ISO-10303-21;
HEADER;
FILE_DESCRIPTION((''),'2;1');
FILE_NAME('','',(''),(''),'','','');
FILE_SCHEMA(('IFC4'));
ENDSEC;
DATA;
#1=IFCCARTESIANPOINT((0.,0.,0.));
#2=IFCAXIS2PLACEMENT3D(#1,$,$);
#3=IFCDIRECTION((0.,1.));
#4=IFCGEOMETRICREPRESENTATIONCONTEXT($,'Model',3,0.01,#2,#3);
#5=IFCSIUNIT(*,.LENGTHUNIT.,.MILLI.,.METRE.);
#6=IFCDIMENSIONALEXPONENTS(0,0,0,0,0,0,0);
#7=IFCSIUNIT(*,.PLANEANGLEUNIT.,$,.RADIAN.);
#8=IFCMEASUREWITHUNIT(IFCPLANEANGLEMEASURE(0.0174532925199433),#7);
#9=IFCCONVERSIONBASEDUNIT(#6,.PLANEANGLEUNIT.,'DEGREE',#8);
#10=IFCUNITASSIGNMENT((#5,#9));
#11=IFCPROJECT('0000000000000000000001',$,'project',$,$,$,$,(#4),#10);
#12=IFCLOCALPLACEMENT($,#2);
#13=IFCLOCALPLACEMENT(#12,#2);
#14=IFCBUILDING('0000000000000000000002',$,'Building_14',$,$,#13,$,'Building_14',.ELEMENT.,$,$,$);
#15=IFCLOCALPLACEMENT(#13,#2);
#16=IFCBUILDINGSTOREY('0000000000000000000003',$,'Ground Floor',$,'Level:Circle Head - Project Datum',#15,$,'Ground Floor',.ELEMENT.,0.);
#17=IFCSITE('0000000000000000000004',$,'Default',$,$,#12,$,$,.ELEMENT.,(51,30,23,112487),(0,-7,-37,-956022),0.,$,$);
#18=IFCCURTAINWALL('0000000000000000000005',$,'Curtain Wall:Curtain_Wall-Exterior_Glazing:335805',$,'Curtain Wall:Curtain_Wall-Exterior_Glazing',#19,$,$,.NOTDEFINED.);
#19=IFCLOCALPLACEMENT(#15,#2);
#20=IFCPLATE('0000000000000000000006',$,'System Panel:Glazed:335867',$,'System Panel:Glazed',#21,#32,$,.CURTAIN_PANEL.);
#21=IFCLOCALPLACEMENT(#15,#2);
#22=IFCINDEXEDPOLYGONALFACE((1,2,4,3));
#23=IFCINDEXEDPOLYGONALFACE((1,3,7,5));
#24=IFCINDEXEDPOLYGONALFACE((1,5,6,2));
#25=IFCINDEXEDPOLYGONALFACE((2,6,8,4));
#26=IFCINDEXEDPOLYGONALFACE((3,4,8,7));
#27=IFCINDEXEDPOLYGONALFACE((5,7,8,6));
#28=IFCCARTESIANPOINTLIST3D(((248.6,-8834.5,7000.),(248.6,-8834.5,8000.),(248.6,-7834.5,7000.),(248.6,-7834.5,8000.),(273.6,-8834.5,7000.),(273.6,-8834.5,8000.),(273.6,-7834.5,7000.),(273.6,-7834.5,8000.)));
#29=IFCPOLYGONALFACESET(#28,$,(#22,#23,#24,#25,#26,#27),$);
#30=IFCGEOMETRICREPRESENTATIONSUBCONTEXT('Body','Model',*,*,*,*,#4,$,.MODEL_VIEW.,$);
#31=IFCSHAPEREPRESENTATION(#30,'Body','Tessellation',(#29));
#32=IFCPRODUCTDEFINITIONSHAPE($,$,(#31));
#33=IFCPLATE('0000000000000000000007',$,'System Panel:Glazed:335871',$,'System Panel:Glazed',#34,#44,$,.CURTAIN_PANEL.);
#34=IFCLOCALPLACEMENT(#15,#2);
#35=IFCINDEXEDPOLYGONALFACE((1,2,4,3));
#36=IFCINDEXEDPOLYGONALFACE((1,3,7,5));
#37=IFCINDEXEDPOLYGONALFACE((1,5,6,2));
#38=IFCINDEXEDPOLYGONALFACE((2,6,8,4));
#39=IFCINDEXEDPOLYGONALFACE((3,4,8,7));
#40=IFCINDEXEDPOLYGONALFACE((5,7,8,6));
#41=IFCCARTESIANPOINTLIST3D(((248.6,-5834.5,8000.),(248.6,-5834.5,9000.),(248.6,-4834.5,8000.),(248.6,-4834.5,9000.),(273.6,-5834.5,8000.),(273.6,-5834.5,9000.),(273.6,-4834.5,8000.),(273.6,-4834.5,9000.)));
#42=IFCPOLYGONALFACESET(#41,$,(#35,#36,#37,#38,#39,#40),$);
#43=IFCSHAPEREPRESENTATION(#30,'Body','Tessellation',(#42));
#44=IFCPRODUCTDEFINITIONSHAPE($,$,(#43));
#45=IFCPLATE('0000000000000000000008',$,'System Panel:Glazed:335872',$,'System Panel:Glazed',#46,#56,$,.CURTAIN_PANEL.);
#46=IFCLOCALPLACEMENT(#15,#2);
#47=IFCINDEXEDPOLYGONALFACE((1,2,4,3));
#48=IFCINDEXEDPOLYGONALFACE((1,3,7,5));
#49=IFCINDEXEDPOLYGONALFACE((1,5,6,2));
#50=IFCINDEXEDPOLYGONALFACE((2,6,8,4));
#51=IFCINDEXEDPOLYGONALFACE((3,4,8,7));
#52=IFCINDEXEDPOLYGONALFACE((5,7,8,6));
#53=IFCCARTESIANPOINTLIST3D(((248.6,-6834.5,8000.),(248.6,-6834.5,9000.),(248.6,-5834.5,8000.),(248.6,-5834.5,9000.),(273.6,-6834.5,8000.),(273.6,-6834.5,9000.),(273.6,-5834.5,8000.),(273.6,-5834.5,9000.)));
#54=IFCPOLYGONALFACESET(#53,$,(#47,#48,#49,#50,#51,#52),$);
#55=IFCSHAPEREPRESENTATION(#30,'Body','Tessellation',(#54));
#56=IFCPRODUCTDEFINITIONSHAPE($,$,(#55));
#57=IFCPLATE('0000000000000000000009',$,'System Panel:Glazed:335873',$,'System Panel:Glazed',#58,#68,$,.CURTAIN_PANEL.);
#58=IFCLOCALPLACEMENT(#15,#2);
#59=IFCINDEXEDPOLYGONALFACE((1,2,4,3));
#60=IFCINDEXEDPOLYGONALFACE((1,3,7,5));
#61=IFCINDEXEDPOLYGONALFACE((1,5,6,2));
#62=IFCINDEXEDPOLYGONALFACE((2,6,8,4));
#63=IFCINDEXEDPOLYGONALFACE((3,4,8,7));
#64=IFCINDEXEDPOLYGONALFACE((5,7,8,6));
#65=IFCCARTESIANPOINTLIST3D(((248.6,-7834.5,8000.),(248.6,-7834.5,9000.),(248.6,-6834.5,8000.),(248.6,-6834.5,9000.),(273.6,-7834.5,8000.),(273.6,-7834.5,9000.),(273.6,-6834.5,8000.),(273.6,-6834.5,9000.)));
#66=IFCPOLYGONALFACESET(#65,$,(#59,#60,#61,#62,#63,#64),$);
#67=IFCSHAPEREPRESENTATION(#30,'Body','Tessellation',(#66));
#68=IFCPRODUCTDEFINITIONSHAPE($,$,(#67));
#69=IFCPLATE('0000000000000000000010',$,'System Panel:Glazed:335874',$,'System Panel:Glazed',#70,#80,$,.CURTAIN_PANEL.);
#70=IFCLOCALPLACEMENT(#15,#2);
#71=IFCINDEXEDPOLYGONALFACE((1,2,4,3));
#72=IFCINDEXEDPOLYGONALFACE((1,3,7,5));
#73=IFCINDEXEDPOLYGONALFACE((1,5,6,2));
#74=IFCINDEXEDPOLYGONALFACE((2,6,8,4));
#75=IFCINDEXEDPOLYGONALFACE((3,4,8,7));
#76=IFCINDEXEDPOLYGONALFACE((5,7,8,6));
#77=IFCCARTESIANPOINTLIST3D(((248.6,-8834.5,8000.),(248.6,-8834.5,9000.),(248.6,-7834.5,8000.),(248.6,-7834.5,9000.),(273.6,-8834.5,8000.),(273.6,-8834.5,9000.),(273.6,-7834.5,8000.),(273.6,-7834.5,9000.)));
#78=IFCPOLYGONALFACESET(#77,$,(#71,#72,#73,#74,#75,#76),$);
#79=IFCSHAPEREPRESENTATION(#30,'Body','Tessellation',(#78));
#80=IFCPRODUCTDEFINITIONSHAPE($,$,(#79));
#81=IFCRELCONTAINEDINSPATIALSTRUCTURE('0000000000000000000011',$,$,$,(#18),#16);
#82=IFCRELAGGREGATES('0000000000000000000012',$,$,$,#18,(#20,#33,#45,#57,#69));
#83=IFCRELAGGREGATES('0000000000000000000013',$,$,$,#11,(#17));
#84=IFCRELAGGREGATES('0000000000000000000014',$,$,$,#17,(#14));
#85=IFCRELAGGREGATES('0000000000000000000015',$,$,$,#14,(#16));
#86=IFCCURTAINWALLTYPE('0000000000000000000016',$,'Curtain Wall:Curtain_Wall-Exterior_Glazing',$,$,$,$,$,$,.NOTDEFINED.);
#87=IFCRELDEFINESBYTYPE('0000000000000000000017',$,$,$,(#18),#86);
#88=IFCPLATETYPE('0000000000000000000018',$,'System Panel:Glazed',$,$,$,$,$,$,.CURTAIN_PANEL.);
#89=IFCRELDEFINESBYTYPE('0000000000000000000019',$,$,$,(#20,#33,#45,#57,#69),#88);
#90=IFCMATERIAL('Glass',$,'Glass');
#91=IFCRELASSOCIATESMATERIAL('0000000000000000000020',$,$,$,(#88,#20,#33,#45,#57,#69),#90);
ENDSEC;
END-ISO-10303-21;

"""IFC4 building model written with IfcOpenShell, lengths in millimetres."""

from ifc_helpers import new_model, entity, si_unit, converted_unit, direction, frame, origin, place, context, subcontext, project, spatial, indexed_curve, outline, extrude, source, transform, mapped, material, type_object, type_shapes, element, aggregate, save


model = new_model("IFC4")

# Units and contexts
model_context = context("Model", 3, precision=0.01, world=origin(), true_north=direction((0.0, 1.0)))
body_context = subcontext(model_context, "Body", "Model", "MODEL_VIEW")
ifc_project = project(units=[si_unit("LENGTHUNIT", "METRE", prefix="MILLI"), converted_unit("PLANEANGLEUNIT", "DEGREE", entity("IfcPlaneAngleMeasure", 0.0174532925199433), si_unit("PLANEANGLEUNIT", "RADIAN"), dimensions=[0, 0, 0, 0, 0, 0, 0])], contexts=[model_context])

# Site, building, storey
site_placement = place(None, origin())
site = spatial("IfcSite", under=ifc_project, at=site_placement, Name="Default", CompositionType="ELEMENT", RefLatitude=(51, 30, 23, 112487), RefLongitude=(0, -7, -37, -956022), RefElevation=0.0)
building_placement = place(site_placement, origin())
building = spatial("IfcBuilding", under=site, at=building_placement, Name="Building_14", LongName="Building_14", CompositionType="ELEMENT")
storey_placement = place(building_placement, origin())
storey = spatial("IfcBuildingStorey", under=building, at=storey_placement, Name="Ground Floor", ObjectType="Level:Circle Head - Project Datum", LongName="Ground Floor", CompositionType="ELEMENT", Elevation=0.0)

# Curtain wall, plates
curtain_wall_type = type_object("IfcCurtainWallType", Name="Curtain Wall:Curtain_Wall-Exterior_Glazing", PredefinedType="NOTDEFINED")
ifc_material = material(Name="Glass", Category="Glass")
plate_type = type_object("IfcPlateType", Name="System Panel:Glazed", PredefinedType="CURTAIN_PANEL", material=ifc_material)
shared_shape = source(origin(), body_context, "Body", "SweptSolid", [
    extrude(outline(indexed_curve([(-12.5, -500.0), (12.5, -500.0), (12.5, 500.0), (-12.5, 500.0), (-12.5, -500.0)], self_intersect=False)), frame((0.0, -37.0, 0.0), z_axis=(0.0, 0.0, 1.0), x_axis=(0.0, 1.0, 0.0)), (0.0, 0.0, 1.0), 1000.0),
])
type_shapes(plate_type, [shared_shape])
curtain_wall_1_placement = place(storey_placement, origin())
curtain_wall_1 = element("IfcCurtainWall", 1, at=curtain_wall_1_placement, inside=storey, type_object=curtain_wall_type, Name="Curtain Wall:Curtain_Wall-Exterior_Glazing:335805", ObjectType="Curtain Wall:Curtain_Wall-Exterior_Glazing", PredefinedType="NOTDEFINED")
plate_1_placement = place(curtain_wall_1_placement, frame((298.1, -8334.5, 7000.0), z_axis=(0.0, 0.0, 1.0), x_axis=(0.0, -1.0, 0.0)))
plate_1 = element("IfcPlate", 2, at=plate_1_placement, type_object=plate_type, material=ifc_material, Name="System Panel:Glazed:335867", ObjectType="System Panel:Glazed", PredefinedType="CURTAIN_PANEL", context=body_context, shape_type="MappedRepresentation", body=[
    mapped(shared_shape, transform((0.0, 0.0, 0.0), scale=1.0)),
])
plate_2_placement = place(curtain_wall_1_placement, frame((298.1, -5334.5, 8000.0), z_axis=(0.0, 0.0, 1.0), x_axis=(0.0, -1.0, 0.0)))
plate_2 = element("IfcPlate", 3, at=plate_2_placement, type_object=plate_type, material=ifc_material, Name="System Panel:Glazed:335871", ObjectType="System Panel:Glazed", PredefinedType="CURTAIN_PANEL", context=body_context, shape_type="MappedRepresentation", body=[
    mapped(shared_shape, transform((0.0, 0.0, 0.0), scale=1.0)),
])
plate_3_placement = place(curtain_wall_1_placement, frame((298.1, -6334.5, 8000.0), z_axis=(0.0, 0.0, 1.0), x_axis=(0.0, -1.0, 0.0)))
plate_3 = element("IfcPlate", 4, at=plate_3_placement, type_object=plate_type, material=ifc_material, Name="System Panel:Glazed:335872", ObjectType="System Panel:Glazed", PredefinedType="CURTAIN_PANEL", context=body_context, shape_type="MappedRepresentation", body=[
    mapped(shared_shape, transform((0.0, 0.0, 0.0), scale=1.0)),
])
plate_4_placement = place(curtain_wall_1_placement, frame((298.1, -7334.5, 8000.0), z_axis=(0.0, 0.0, 1.0), x_axis=(0.0, -1.0, 0.0)))
plate_4 = element("IfcPlate", 5, at=plate_4_placement, type_object=plate_type, material=ifc_material, Name="System Panel:Glazed:335873", ObjectType="System Panel:Glazed", PredefinedType="CURTAIN_PANEL", context=body_context, shape_type="MappedRepresentation", body=[
    mapped(shared_shape, transform((0.0, 0.0, 0.0), scale=1.0)),
])
plate_5_placement = place(curtain_wall_1_placement, frame((298.1, -8334.5, 8000.0), z_axis=(0.0, 0.0, 1.0), x_axis=(0.0, -1.0, 0.0)))
plate_5 = element("IfcPlate", 6, at=plate_5_placement, type_object=plate_type, material=ifc_material, Name="System Panel:Glazed:335874", ObjectType="System Panel:Glazed", PredefinedType="CURTAIN_PANEL", context=body_context, shape_type="MappedRepresentation", body=[
    mapped(shared_shape, transform((0.0, 0.0, 0.0), scale=1.0)),
])
aggregate(curtain_wall_1, [plate_1, plate_2, plate_3, plate_4, plate_5])

save(model, "model.ifc")
